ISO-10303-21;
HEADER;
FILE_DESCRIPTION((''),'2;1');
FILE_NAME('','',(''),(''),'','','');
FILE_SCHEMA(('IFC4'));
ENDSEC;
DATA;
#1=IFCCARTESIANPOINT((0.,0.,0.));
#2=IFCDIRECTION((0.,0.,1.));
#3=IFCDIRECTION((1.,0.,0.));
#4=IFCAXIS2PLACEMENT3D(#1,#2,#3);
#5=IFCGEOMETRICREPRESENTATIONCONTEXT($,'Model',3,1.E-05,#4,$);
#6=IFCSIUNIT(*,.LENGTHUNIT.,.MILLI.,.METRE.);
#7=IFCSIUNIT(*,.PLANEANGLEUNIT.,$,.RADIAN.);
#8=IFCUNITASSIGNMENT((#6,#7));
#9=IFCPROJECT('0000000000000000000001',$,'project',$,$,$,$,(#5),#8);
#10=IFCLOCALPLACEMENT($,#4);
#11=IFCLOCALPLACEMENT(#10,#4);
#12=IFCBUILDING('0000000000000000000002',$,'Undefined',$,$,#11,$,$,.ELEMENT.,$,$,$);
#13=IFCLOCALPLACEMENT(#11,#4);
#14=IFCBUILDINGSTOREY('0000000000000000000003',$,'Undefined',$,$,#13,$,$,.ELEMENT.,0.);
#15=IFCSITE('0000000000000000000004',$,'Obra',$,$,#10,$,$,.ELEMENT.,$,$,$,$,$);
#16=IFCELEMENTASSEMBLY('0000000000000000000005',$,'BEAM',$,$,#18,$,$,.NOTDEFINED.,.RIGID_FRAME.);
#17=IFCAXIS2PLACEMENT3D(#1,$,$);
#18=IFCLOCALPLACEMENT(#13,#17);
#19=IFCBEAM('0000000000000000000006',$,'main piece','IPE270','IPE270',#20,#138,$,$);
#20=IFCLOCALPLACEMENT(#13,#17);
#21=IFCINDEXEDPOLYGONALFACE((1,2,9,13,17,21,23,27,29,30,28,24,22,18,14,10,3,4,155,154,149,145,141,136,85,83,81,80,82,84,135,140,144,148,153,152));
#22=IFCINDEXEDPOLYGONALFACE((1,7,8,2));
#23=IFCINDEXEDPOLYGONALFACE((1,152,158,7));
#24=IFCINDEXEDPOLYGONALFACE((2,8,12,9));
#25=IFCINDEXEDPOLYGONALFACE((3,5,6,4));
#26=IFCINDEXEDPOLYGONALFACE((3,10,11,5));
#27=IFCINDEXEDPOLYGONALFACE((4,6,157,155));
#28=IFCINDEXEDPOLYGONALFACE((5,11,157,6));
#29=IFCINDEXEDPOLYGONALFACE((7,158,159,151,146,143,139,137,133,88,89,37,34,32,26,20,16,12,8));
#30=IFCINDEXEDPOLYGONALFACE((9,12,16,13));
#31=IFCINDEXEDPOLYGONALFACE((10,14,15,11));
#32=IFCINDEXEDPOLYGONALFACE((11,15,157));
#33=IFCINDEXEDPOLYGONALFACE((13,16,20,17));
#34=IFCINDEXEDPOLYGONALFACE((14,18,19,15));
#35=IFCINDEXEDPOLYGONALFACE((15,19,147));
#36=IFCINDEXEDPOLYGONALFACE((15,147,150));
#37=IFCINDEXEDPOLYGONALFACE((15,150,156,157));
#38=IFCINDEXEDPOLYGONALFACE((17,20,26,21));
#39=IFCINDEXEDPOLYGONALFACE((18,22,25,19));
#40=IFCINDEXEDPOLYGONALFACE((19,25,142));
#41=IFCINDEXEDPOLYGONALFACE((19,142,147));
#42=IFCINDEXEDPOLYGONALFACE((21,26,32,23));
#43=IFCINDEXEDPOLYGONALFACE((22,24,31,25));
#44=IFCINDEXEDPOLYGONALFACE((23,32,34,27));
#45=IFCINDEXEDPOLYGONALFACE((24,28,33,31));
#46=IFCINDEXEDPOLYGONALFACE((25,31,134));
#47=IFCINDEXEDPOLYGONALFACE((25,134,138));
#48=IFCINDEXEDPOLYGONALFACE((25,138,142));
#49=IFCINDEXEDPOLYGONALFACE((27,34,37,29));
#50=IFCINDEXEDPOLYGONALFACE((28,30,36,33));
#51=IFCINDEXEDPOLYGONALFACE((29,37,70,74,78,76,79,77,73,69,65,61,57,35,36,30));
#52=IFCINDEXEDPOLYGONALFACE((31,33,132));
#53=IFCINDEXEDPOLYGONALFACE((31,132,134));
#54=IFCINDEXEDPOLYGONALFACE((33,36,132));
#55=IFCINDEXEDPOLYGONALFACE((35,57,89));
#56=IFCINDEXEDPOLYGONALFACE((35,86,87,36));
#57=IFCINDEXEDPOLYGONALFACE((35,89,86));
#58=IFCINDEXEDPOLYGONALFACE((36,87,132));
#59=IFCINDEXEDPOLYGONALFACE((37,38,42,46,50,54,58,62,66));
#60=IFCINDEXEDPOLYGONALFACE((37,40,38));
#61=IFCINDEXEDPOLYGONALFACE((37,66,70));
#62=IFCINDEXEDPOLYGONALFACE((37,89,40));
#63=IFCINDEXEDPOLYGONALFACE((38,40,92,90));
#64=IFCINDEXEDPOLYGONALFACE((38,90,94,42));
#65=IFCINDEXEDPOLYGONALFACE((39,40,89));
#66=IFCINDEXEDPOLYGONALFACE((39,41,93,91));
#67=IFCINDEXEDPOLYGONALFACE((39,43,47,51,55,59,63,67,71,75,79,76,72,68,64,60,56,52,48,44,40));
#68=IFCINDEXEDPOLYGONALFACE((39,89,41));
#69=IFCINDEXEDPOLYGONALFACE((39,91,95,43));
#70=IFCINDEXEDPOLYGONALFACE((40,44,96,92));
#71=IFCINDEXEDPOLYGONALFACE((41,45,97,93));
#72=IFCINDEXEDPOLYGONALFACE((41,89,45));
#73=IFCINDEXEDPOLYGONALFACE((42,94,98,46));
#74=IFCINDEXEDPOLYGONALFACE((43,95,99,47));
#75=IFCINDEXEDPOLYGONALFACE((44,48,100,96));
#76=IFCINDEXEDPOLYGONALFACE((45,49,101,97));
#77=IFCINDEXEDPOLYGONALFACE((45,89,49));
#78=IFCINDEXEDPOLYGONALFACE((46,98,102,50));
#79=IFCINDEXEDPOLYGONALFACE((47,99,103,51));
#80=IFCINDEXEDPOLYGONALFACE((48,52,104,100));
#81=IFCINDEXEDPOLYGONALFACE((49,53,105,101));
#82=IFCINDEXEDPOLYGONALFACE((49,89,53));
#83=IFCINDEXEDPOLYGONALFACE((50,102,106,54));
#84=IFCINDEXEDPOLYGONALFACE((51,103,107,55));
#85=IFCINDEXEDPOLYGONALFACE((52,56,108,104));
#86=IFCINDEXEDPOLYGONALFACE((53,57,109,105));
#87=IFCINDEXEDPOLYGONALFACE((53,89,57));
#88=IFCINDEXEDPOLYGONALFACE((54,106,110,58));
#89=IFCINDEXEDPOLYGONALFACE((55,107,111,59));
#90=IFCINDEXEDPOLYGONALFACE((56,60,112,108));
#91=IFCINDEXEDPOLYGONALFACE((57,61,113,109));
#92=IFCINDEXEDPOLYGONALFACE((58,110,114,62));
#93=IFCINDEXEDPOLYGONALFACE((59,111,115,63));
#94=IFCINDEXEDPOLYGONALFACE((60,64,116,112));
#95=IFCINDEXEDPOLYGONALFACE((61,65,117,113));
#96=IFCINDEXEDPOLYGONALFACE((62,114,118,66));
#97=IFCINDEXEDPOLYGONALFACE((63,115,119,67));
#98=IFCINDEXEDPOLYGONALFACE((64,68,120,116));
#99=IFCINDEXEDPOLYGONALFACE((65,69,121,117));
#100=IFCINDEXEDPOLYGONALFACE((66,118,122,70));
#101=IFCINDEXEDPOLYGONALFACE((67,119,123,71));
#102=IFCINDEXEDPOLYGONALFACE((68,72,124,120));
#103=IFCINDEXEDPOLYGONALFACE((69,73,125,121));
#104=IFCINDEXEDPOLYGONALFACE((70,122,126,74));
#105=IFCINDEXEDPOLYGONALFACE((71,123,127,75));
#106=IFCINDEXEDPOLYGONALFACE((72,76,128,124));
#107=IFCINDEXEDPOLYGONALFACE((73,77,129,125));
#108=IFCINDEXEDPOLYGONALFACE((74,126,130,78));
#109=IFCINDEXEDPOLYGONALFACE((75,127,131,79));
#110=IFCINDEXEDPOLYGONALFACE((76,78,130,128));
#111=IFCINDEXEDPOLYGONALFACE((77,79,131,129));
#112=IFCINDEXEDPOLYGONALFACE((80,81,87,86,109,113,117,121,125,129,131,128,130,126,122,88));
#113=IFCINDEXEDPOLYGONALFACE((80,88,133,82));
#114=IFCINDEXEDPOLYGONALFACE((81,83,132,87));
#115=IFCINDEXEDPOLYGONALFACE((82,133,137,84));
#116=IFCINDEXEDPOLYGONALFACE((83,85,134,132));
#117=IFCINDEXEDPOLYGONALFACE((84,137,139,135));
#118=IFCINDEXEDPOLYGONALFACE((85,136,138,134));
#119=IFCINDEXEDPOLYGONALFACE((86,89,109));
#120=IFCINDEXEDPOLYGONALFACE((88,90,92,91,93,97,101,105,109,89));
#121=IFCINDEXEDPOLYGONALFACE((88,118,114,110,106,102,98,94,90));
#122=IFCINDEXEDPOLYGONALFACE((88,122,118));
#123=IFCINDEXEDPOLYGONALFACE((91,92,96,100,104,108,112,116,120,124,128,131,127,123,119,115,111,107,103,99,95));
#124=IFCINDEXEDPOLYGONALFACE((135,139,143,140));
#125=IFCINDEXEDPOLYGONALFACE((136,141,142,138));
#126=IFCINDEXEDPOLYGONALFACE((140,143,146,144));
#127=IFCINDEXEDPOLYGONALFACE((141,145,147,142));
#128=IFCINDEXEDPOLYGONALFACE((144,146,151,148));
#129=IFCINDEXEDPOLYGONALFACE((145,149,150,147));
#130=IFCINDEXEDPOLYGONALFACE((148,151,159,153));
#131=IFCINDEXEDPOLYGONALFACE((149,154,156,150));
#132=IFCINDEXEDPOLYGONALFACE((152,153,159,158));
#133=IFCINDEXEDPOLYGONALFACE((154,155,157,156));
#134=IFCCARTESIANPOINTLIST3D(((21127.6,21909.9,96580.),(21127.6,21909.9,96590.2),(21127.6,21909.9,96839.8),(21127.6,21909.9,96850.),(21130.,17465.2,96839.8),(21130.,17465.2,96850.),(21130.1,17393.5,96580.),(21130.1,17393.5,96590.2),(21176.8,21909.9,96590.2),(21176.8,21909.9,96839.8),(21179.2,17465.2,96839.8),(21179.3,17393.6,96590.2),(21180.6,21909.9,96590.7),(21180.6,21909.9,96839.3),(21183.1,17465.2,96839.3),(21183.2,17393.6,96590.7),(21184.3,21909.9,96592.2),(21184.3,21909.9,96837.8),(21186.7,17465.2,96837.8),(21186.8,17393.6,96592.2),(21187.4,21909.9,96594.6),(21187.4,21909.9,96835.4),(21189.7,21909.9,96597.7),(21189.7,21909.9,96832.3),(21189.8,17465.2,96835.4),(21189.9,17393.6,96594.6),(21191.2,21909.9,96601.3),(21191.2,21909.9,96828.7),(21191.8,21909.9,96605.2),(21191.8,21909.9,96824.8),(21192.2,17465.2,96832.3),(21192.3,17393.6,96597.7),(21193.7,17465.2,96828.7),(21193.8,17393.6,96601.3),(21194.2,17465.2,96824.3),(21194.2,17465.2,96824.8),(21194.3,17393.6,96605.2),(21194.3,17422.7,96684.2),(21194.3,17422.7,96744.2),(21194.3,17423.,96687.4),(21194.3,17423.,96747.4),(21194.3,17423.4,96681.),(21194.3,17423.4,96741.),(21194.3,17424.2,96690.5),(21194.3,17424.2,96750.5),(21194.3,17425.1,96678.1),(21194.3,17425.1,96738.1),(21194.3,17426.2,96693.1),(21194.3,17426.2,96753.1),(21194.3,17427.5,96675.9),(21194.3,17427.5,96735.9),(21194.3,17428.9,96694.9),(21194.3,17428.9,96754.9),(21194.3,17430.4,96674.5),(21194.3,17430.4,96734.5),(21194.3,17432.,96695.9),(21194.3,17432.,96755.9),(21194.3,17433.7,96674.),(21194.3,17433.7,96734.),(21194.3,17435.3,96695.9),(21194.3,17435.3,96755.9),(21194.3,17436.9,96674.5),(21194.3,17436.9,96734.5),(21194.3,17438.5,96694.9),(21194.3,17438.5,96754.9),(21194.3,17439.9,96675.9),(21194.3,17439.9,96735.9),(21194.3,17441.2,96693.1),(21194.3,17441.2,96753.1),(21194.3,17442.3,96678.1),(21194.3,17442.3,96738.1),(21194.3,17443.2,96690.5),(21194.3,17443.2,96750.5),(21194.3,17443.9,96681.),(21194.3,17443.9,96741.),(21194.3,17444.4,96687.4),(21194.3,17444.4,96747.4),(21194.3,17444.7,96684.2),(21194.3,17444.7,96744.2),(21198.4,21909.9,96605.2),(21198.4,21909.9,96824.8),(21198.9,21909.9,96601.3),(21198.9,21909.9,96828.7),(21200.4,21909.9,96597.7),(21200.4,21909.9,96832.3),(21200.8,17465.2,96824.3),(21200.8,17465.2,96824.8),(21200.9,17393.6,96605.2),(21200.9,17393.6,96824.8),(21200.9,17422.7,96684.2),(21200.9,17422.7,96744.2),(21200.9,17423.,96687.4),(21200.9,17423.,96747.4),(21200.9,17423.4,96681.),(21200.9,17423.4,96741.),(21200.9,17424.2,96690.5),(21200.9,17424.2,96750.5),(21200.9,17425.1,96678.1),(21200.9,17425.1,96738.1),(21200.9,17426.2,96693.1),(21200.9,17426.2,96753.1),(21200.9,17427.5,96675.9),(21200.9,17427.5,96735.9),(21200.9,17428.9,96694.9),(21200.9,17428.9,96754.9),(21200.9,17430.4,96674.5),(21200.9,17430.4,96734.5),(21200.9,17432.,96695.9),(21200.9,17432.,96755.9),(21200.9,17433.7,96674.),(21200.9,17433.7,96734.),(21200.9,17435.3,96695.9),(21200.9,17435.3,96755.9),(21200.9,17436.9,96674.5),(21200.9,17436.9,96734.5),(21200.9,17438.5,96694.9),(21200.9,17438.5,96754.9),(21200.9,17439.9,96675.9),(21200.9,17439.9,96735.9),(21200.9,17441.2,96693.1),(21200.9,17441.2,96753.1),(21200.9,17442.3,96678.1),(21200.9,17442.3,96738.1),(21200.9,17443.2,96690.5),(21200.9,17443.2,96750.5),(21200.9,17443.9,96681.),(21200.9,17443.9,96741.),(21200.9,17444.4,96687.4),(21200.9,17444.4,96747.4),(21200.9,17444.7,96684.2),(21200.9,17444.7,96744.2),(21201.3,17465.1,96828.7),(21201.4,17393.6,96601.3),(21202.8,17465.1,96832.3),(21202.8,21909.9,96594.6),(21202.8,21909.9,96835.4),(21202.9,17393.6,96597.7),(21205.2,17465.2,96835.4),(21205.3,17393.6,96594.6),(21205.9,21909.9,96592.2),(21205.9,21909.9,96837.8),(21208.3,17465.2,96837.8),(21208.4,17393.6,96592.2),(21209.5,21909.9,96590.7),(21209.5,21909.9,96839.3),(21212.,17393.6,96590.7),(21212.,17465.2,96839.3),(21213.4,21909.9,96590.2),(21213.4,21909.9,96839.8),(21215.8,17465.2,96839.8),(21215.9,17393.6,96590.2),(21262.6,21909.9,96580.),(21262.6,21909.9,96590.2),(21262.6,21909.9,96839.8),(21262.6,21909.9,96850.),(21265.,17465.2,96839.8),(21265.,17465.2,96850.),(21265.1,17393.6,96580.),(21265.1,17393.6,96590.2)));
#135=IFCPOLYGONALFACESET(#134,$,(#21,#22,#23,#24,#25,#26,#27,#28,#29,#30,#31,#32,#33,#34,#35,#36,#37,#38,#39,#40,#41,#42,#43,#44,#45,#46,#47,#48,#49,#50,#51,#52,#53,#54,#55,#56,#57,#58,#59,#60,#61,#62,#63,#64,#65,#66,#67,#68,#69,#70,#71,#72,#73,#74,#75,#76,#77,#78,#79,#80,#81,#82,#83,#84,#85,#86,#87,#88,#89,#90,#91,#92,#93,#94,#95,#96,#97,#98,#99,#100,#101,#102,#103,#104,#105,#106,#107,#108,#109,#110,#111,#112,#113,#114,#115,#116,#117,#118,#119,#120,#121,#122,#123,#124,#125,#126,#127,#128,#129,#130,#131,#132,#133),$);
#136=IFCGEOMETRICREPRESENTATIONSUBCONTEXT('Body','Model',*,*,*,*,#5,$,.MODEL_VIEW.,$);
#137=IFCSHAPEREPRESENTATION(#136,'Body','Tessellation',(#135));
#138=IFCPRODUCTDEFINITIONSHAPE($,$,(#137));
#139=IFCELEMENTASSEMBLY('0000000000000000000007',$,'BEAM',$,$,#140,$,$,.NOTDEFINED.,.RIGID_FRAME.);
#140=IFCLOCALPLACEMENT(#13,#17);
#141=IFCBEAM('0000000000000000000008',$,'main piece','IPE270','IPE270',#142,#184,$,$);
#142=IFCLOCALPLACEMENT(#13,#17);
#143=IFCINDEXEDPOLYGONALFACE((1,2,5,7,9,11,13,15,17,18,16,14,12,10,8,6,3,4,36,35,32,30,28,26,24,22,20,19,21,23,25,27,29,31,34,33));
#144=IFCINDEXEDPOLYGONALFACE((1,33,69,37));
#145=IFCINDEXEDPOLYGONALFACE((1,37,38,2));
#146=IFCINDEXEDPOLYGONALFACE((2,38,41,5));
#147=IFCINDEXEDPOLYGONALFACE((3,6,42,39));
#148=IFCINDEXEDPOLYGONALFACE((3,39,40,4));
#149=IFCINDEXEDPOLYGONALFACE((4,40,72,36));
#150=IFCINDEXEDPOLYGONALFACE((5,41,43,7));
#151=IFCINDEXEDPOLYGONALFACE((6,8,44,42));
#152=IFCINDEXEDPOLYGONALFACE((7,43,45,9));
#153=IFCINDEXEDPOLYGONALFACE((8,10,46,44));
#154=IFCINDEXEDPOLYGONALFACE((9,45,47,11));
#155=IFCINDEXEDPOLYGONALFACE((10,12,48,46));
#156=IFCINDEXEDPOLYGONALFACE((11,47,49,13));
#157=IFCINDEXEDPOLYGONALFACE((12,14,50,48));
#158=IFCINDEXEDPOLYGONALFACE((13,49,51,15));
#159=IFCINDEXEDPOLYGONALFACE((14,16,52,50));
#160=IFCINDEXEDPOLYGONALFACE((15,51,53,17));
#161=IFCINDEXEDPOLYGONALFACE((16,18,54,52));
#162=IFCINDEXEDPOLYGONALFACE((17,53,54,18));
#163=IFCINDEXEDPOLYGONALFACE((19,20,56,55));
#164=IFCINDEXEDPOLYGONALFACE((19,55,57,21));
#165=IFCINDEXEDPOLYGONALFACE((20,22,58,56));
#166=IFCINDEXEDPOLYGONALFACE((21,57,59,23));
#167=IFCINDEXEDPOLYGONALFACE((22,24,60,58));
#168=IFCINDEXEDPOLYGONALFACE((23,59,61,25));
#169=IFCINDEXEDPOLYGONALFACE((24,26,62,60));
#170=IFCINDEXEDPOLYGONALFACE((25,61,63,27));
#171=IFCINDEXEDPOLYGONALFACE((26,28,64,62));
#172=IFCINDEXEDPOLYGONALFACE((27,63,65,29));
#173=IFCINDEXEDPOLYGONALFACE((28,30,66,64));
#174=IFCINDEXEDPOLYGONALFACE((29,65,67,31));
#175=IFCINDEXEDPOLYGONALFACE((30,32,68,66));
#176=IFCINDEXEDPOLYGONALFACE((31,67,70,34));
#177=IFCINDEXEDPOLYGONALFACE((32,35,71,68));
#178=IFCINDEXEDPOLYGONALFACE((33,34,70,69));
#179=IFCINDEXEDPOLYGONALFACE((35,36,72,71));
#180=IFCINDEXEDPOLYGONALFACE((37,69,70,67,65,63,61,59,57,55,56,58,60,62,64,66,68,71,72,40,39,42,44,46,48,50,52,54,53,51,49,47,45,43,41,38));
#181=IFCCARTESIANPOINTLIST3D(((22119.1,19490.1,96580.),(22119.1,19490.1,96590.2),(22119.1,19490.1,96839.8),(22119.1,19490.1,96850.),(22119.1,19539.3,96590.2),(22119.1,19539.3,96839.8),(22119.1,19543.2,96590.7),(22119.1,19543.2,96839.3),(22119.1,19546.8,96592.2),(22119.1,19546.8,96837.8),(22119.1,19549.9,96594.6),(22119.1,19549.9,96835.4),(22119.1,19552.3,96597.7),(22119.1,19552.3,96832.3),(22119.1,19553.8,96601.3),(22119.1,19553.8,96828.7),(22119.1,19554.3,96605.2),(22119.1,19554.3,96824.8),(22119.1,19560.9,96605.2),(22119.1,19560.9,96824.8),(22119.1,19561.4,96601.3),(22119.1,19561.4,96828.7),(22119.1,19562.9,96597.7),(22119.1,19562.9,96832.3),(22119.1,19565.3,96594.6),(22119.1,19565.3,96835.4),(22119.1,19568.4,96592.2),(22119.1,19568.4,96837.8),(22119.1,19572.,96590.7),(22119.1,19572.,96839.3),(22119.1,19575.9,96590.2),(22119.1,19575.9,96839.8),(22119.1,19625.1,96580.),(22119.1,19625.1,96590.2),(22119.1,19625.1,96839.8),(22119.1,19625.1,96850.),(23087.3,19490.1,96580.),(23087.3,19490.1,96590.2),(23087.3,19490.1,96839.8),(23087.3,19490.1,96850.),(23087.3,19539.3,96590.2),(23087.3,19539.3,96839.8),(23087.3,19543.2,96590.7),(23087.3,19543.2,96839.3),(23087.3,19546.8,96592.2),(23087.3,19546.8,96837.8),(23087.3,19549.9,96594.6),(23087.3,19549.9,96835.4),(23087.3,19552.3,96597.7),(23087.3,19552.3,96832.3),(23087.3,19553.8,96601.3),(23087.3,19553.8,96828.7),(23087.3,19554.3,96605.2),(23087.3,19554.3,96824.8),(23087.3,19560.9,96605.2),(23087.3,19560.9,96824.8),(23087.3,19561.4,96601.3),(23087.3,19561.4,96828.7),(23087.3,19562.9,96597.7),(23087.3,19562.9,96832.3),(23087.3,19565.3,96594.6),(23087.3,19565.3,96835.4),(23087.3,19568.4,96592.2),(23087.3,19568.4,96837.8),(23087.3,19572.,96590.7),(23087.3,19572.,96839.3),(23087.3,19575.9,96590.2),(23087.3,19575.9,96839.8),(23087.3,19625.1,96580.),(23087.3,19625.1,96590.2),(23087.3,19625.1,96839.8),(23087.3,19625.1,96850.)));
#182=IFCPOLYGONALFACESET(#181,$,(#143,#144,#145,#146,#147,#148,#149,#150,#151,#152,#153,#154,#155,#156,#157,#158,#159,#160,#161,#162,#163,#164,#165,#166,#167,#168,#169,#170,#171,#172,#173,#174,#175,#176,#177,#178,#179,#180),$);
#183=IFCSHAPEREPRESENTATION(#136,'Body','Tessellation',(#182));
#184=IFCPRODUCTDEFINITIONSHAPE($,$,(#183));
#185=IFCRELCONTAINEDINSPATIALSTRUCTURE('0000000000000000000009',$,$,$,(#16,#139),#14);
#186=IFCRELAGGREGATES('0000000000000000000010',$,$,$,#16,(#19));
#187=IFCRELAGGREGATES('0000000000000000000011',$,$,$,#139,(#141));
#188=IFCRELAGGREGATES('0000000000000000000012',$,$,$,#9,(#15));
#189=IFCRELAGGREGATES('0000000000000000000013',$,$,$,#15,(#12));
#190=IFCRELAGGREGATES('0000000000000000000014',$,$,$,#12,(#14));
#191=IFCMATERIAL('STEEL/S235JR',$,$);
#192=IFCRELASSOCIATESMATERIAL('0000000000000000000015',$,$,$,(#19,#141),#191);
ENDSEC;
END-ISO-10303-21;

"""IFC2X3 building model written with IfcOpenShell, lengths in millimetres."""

from ifc_helpers import new_model, si_unit, frame, origin_with_axes, origin_2d_with_axis, place, context, subcontext, project, spatial, rectangle, circle, i_section, extrude, clip, halfspace, source, transform, mapped, material, element, aggregate, save


model = new_model("IFC2X3")

# Units and contexts
model_context = context("Model", 3, precision=1e-05, world=origin_with_axes())
body_context = subcontext(model_context, "Body", "Model", "MODEL_VIEW")
ifc_project = project(units=[si_unit("LENGTHUNIT", "METRE", prefix="MILLI"), si_unit("PLANEANGLEUNIT", "RADIAN")], contexts=[model_context])

# Site, building, storey
site_placement = place(None, origin_with_axes())
site = spatial("IfcSite", under=ifc_project, at=site_placement, Name="Obra", CompositionType="ELEMENT")
building_placement = place(site_placement, origin_with_axes())
building = spatial("IfcBuilding", under=site, at=building_placement, Name="Undefined", CompositionType="ELEMENT")
storey_placement = place(building_placement, origin_with_axes())
storey = spatial("IfcBuildingStorey", under=building, at=storey_placement, Name="Undefined", CompositionType="ELEMENT", Elevation=0.0)

# Shared definitions
ifc_material = material(Name="STEEL/S235JR")

# Element assembly, beam, openings
assembly_1_placement = place(storey_placement, origin_with_axes())
assembly_1 = element("IfcElementAssembly", 1, at=assembly_1_placement, inside=storey, Name="BEAM", AssemblyPlace="NOTDEFINED", PredefinedType="RIGID_FRAME")
beam_1_placement = place(assembly_1_placement, frame((21197.5, 17475.1, 96715.0), z_axis=(0.0, 0.0, 1.0), x_axis=(-0.000557, 1.0, 0.0)))
beam_1 = element("IfcBeam", 2, at=beam_1_placement, material=ifc_material, Name="main piece", Description="IPE270", ObjectType="IPE270", context=body_context, shape_type="Clipping", body=[
    clip(extrude(i_section(OverallWidth=135.0, OverallDepth=270.0, WebThickness=6.6, FlangeThickness=10.2, FilletRadius=15.0, at=origin_2d_with_axis()), frame((4434.8, 0.0, 0.0), z_axis=(-1.0, 0.0, 0.0), x_axis=(0.0, -1.0, 0.0)), (0.0, 0.0, 1.0), 4516.3), halfspace(frame((-81.4, 0.0, -235.0), z_axis=(1.0, -0.000557, 0.0), x_axis=(-0.000557, -1.0, 0.0)), True)),
])
opening_1_placement = place(assembly_1_placement, frame((21197.5, 17475.1, 96715.0), z_axis=(0.0, 0.0, 1.0), x_axis=(-0.000557, 1.0, 0.0)))
element("IfcOpeningElement", 3, at=opening_1_placement, cuts=beam_1, ObjectType="Recess", context=body_context, shape_type="SweptSolid", body=[
    extrude(rectangle(XDim=75.0, YDim=300.0, at=origin_2d_with_axis()), frame((-54.0, -153.3, 124.3), z_axis=(0.0, 0.0, -1.0), x_axis=(1.0, -0.000557, 0.0)), (0.0, 0.0, 1.0), 278.6),
])
opening_2_placement = place(assembly_1_placement, frame((21197.5, 17475.1, 96715.0), z_axis=(0.0, 0.0, 1.0), x_axis=(-0.000557, 1.0, 0.0)))
element("IfcOpeningElement", 4, at=opening_2_placement, cuts=beam_1, ObjectType="Recess", context=body_context, shape_type="SweptSolid", body=[
    extrude(rectangle(XDim=26.7, YDim=83.5, at=origin_2d_with_axis()), frame((-51.7, -68.5, 122.7), z_axis=(0.000557, 1.0, 0.0), x_axis=(0.0, 0.0, -1.0)), (0.0, 0.0, 1.0), 139.5),
])
shared_shape_1 = source(origin_with_axes(), body_context, "Body", "SweptSolid", [
    extrude(circle(Radius=11.0, at=origin_2d_with_axis()), frame((0.0, -3.4, 0.0), z_axis=(0.0, 1.0, 0.0), x_axis=(1.0, 0.0, 0.0)), (0.0, 0.0, 1.0), 6.8),
])
opening_3_placement = place(assembly_1_placement, frame((21197.6, 17393.7, 96850.0), z_axis=(0.0, 1.0, 0.0), x_axis=(0.0, 0.0, -1.0)))
element("IfcOpeningElement", 5, at=opening_3_placement, cuts=beam_1, ObjectType="Opening", context=body_context, shape_type="MappedRepresentation", body=[
    mapped(shared_shape_1, transform((105.0, 0.0, 40.0))),
    mapped(shared_shape_1, transform((165.0, 0.0, 40.0))),
])
aggregate(assembly_1, [beam_1])

# Element assembly, beam
assembly_2_placement = place(storey_placement, origin_with_axes())
assembly_2 = element("IfcElementAssembly", 6, at=assembly_2_placement, inside=storey, Name="BEAM", AssemblyPlace="NOTDEFINED", PredefinedType="RIGID_FRAME")
beam_2_placement = place(assembly_2_placement, frame((22119.1, 19557.6, 96715.0), z_axis=(0.0, 0.0, 1.0), x_axis=(1.0, 0.0, 0.0)))
beam_2 = element("IfcBeam", 7, at=beam_2_placement, material=ifc_material, Name="main piece", Description="IPE270", ObjectType="IPE270", context=body_context, shape_type="SweptSolid", body=[
    extrude(i_section(OverallWidth=135.0, OverallDepth=270.0, WebThickness=6.6, FlangeThickness=10.2, FilletRadius=15.0, at=origin_2d_with_axis()), frame((968.2, 0.0, 0.0), z_axis=(-1.0, 0.0, 0.0), x_axis=(0.0, -1.0, 0.0)), (0.0, 0.0, 1.0), 968.2),
])
aggregate(assembly_2, [beam_2])

save(model, "model.ifc")
